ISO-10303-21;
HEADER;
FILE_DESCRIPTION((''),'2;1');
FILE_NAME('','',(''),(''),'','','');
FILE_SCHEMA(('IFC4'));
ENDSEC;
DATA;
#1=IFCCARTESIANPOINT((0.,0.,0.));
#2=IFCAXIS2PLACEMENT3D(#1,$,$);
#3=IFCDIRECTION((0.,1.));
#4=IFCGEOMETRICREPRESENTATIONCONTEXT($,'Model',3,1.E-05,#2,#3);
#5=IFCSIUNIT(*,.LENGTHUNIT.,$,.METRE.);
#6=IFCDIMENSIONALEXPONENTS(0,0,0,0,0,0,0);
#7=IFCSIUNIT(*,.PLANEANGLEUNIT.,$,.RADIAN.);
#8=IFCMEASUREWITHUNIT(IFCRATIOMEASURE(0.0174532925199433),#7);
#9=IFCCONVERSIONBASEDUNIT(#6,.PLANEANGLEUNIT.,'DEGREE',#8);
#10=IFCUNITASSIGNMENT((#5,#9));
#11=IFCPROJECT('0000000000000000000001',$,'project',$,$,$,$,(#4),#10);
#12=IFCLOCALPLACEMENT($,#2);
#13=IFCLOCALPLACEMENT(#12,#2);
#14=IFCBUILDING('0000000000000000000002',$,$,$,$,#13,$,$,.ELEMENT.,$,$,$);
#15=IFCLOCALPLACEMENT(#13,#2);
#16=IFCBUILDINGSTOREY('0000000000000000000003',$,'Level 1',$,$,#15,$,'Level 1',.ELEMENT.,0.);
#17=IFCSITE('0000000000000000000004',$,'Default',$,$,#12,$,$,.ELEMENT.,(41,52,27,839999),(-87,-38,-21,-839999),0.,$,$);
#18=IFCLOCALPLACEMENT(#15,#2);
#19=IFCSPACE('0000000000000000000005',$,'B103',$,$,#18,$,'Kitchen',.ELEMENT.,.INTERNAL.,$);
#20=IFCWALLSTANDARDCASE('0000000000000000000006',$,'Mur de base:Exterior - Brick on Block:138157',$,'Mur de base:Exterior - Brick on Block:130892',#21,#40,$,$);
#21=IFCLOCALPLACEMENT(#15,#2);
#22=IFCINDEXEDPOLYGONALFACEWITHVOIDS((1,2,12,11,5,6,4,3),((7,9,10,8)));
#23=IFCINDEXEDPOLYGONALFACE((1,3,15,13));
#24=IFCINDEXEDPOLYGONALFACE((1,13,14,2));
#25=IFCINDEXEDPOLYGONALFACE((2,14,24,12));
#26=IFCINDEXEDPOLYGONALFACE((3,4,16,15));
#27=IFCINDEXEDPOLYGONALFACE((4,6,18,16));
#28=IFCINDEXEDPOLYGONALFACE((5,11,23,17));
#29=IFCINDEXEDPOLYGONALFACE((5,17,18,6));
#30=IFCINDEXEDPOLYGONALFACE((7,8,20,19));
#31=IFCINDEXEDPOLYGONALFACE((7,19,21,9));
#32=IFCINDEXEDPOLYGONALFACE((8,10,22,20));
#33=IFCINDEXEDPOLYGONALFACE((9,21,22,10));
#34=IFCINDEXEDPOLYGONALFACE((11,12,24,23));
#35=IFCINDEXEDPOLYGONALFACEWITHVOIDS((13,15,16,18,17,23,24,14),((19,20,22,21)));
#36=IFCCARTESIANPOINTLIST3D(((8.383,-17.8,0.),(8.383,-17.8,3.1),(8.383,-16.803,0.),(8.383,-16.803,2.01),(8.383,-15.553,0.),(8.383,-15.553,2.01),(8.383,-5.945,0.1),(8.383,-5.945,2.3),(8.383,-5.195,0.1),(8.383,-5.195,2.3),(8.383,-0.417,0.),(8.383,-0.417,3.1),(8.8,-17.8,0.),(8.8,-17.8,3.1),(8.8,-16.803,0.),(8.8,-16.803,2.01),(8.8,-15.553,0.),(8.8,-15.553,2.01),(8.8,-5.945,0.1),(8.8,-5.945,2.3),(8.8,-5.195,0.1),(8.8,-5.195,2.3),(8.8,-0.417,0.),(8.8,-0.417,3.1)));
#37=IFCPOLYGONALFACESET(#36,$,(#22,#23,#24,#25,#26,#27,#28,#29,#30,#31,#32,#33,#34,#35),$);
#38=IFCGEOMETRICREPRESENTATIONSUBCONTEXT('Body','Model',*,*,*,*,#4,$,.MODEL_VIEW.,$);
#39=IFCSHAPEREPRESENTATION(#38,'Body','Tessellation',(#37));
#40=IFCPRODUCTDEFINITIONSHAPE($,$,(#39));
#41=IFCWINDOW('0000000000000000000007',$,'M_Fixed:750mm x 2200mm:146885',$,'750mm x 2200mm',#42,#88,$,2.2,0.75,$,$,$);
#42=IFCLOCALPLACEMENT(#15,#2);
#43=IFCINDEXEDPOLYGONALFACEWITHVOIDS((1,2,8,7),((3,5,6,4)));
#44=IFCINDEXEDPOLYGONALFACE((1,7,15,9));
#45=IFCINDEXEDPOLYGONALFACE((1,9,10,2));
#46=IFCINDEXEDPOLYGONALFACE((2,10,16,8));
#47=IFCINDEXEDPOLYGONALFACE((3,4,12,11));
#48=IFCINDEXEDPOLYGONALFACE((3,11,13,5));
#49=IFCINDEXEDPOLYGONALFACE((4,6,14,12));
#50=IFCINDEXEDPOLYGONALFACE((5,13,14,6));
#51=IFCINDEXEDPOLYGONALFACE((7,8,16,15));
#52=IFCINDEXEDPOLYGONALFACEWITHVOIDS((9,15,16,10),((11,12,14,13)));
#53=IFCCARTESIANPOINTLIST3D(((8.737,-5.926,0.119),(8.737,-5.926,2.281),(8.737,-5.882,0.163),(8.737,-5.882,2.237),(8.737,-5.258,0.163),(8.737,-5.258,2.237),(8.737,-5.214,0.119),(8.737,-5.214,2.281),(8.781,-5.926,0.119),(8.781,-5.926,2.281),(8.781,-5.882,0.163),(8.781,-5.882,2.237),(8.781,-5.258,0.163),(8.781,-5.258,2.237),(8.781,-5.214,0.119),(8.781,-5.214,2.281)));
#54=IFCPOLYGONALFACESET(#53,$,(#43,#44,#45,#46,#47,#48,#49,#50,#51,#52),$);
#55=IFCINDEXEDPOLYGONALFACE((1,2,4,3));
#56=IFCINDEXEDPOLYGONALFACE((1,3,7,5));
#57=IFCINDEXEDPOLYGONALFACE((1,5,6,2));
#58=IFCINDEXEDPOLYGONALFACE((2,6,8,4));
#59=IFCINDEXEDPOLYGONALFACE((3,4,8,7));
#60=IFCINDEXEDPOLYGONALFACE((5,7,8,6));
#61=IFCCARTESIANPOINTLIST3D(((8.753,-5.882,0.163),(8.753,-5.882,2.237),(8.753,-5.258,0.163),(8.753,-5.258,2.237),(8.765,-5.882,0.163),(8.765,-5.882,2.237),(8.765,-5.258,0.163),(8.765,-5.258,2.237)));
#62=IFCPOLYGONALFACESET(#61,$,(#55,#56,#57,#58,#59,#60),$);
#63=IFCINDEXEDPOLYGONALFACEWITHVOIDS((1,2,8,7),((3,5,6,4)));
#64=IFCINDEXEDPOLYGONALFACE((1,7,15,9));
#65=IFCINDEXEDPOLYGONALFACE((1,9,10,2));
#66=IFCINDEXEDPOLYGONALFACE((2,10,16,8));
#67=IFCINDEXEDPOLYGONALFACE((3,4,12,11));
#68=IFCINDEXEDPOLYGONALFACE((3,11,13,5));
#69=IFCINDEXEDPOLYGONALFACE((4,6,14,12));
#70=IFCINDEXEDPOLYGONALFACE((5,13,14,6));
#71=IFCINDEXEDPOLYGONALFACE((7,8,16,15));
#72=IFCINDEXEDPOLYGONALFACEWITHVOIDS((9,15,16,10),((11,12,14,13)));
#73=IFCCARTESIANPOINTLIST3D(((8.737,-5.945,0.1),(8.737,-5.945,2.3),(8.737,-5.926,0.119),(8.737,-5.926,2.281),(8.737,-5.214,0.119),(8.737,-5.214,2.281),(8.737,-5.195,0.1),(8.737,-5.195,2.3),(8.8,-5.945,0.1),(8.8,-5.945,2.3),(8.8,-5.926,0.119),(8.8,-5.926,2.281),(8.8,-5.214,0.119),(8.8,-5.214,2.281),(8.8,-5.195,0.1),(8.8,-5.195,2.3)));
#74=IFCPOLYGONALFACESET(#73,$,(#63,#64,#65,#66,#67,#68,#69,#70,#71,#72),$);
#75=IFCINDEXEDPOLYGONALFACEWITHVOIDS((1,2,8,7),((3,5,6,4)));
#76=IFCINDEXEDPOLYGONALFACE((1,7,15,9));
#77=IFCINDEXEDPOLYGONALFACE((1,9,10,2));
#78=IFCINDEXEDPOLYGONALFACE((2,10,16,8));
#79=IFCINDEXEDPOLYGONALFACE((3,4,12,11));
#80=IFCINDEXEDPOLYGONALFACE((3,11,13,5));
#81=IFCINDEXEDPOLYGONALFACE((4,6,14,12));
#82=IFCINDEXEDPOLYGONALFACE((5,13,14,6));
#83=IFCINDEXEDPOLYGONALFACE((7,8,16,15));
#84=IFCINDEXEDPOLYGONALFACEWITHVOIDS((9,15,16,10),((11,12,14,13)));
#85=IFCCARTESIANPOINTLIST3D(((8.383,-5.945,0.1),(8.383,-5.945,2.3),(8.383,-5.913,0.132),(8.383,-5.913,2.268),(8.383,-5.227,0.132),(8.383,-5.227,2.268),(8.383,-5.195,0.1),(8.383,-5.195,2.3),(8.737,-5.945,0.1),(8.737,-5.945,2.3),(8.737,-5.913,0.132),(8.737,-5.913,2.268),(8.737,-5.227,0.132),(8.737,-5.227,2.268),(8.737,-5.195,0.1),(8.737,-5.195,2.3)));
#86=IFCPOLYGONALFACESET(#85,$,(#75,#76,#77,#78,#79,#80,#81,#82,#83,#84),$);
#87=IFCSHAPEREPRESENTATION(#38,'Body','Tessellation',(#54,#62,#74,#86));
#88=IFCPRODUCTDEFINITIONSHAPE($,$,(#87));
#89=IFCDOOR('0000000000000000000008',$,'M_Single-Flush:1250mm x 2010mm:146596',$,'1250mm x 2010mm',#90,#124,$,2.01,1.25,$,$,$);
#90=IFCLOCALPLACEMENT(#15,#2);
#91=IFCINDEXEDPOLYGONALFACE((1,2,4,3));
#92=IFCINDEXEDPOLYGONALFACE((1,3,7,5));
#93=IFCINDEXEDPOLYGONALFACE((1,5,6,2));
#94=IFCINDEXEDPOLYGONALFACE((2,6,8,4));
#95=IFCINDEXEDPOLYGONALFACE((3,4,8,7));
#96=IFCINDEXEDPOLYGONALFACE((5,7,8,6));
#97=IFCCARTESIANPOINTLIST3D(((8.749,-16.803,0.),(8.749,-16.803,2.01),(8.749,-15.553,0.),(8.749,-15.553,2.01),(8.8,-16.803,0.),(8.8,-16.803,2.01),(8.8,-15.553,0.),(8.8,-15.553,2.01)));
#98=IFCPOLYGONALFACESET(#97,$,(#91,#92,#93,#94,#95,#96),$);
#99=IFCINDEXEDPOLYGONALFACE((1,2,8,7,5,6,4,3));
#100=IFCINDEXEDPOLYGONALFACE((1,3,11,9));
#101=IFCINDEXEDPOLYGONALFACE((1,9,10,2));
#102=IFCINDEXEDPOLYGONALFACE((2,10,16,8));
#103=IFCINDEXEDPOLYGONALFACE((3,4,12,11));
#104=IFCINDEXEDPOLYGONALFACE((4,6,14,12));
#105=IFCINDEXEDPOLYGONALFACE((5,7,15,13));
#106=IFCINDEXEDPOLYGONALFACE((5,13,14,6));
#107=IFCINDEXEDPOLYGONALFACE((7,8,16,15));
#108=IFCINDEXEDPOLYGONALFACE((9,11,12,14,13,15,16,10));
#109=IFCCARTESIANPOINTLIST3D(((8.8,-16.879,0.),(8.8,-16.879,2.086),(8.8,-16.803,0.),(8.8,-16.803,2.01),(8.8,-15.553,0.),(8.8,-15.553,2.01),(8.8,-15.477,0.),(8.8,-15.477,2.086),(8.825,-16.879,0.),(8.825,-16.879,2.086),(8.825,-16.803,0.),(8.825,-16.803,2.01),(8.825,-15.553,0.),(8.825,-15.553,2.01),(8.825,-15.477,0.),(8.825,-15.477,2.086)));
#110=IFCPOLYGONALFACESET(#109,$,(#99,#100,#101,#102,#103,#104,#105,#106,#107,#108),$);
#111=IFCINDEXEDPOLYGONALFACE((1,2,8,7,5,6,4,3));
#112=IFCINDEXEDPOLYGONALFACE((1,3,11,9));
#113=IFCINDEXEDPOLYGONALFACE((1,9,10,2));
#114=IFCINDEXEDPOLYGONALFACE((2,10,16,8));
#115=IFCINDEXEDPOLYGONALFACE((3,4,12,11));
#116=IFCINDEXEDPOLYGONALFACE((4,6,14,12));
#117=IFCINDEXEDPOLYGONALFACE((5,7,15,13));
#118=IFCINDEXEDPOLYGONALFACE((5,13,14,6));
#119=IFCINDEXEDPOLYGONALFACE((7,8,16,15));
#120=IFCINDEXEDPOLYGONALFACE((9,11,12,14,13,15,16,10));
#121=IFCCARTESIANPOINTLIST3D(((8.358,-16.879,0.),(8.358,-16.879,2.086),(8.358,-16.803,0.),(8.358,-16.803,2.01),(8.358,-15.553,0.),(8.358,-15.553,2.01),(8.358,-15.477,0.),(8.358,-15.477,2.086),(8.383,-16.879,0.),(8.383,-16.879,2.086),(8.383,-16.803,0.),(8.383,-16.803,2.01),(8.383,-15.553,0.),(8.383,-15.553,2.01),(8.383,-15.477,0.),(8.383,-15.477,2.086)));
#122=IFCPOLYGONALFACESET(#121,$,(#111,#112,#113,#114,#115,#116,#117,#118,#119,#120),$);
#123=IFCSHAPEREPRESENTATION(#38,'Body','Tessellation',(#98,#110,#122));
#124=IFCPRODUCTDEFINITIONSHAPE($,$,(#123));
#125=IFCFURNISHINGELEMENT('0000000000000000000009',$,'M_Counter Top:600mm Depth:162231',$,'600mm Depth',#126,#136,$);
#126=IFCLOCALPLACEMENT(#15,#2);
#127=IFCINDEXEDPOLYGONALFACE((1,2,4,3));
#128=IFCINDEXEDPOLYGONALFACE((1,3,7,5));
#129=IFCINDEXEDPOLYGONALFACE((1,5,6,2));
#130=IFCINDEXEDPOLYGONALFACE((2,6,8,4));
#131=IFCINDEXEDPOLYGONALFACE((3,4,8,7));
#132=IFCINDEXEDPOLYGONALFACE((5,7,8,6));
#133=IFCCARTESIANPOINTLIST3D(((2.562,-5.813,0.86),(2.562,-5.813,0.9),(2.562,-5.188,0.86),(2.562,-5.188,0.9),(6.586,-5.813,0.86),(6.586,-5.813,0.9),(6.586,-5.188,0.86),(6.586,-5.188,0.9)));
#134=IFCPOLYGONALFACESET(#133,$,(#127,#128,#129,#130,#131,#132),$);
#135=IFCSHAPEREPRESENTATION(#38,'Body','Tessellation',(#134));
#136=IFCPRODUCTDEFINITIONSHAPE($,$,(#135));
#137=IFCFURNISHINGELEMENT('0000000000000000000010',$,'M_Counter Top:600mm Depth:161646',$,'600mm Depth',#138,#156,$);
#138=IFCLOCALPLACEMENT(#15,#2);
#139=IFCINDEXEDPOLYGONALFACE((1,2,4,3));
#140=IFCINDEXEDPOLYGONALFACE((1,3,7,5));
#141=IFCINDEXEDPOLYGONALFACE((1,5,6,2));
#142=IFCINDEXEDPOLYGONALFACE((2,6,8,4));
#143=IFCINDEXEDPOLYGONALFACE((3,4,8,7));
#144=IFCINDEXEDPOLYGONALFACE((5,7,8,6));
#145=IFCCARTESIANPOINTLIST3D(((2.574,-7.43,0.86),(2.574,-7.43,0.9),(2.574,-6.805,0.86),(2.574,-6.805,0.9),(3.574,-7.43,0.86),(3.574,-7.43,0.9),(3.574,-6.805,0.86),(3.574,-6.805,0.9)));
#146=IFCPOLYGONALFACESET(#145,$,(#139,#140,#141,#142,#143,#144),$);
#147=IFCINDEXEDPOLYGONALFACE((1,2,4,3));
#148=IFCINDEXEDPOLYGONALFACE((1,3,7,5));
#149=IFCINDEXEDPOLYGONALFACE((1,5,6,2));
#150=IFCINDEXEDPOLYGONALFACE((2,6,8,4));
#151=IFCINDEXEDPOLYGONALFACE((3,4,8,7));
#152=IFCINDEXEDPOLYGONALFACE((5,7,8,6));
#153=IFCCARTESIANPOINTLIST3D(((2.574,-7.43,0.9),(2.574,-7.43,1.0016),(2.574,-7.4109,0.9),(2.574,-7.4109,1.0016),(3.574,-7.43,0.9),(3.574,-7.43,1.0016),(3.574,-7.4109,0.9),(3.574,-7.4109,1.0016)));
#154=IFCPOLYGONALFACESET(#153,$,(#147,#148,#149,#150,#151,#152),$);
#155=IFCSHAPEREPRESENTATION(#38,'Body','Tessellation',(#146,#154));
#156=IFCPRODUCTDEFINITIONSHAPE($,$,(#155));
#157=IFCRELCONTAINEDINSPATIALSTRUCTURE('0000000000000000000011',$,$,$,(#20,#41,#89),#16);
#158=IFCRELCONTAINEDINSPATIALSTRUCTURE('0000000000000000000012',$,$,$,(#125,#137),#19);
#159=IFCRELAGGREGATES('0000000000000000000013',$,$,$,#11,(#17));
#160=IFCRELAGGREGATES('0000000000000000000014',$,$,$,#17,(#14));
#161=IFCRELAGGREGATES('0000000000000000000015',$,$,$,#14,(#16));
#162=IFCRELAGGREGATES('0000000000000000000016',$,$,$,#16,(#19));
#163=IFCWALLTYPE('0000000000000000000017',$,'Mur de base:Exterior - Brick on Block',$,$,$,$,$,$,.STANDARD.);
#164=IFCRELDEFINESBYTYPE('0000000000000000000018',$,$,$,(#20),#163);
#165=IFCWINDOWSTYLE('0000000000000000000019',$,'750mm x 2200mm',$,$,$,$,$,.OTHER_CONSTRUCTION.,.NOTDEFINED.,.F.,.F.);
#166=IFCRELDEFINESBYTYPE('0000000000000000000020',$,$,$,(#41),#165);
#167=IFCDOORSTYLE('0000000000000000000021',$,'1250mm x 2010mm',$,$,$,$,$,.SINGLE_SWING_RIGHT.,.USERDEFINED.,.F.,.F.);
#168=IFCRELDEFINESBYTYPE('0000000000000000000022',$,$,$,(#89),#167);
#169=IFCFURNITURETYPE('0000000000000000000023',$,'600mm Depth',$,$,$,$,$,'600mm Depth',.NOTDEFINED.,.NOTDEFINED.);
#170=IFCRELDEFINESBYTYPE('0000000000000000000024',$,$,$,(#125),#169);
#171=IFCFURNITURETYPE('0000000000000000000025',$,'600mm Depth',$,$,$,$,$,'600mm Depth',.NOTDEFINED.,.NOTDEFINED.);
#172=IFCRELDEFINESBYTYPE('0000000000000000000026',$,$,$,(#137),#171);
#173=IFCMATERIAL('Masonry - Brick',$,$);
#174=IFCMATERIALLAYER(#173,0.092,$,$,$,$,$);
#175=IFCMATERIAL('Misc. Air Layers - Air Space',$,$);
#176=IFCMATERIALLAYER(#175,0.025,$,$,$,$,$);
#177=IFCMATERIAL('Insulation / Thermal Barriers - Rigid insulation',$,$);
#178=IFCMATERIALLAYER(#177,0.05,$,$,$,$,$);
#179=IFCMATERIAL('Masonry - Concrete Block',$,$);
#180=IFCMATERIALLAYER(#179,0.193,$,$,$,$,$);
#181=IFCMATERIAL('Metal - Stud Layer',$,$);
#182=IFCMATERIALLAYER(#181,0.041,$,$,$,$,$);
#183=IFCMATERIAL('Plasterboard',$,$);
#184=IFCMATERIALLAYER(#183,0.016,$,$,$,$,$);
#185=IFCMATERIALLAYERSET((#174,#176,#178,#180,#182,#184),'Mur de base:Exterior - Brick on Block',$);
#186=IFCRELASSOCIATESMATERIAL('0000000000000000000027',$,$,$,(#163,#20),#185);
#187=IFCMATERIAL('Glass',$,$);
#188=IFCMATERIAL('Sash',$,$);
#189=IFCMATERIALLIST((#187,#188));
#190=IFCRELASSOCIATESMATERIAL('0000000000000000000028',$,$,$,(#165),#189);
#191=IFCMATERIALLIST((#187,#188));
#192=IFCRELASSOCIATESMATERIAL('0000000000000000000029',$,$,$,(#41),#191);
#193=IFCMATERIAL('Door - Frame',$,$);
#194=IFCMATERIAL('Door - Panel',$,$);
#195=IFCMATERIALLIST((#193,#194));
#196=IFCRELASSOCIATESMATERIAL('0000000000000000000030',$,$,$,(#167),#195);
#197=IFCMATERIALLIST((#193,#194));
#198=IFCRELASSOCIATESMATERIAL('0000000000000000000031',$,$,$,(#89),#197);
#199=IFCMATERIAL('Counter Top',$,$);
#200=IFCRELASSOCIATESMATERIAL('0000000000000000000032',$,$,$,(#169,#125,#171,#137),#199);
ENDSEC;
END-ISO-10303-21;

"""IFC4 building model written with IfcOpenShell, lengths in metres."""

from ifc_helpers import new_model, entity, si_unit, converted_unit, direction, frame, frame_2d, origin, origin_2d_with_axis, place, context, subcontext, project, spatial, polyline, rectangle, outline, extrude, source, transform, mapped, material, material_list, layer, layer_set, layer_usage, type_object, type_shapes, element, fill, save


model = new_model("IFC4")

# Units and contexts
model_context = context("Model", 3, precision=1e-05, world=origin(), true_north=direction((0.0, 1.0)))
body_context = subcontext(model_context, "Body", "Model", "MODEL_VIEW")
ifc_project = project(units=[si_unit("LENGTHUNIT", "METRE"), converted_unit("PLANEANGLEUNIT", "DEGREE", entity("IfcRatioMeasure", 0.0174532925199433), si_unit("PLANEANGLEUNIT", "RADIAN"), dimensions=[0, 0, 0, 0, 0, 0, 0])], contexts=[model_context])

# Site, building, storey
site_placement = place(None, origin())
site = spatial("IfcSite", under=ifc_project, at=site_placement, Name="Default", CompositionType="ELEMENT", RefLatitude=(41, 52, 27, 839999), RefLongitude=(-87, -38, -21, -839999), RefElevation=0.0)
building_placement = place(site_placement, origin())
building = spatial("IfcBuilding", under=site, at=building_placement, CompositionType="ELEMENT")
storey_placement = place(building_placement, origin())
storey = spatial("IfcBuildingStorey", under=building, at=storey_placement, Name="Level 1", LongName="Level 1", CompositionType="ELEMENT", Elevation=0.0)

# Shared definitions
ifc_material_1 = material(Name="Metal - Stud Layer")
ifc_material_2 = material(Name="Plasterboard")
ifc_material_3 = material(Name="Masonry - Concrete Block")
ifc_material_4 = material(Name="Misc. Air Layers - Air Space")

# Shared definitions
ifc_material_5 = material(Name="Door - Frame")
ifc_material_6 = material(Name="Door - Panel")

# Wall, openings, window, door
ifc_material_7 = material(Name="Masonry - Brick")
ifc_layer_1 = layer(ifc_material_7, 0.092)
ifc_layer_2 = layer(ifc_material_4, 0.025)
ifc_material_8 = material(Name="Insulation / Thermal Barriers - Rigid insulation")
ifc_layer_3 = layer(ifc_material_8, 0.05)
ifc_layer_4 = layer(ifc_material_3, 0.193)
ifc_layer_5 = layer(ifc_material_1, 0.041)
ifc_layer_6 = layer(ifc_material_2, 0.016)
ifc_layer_set_1 = layer_set([ifc_layer_1, ifc_layer_2, ifc_layer_3, ifc_layer_4, ifc_layer_5, ifc_layer_6], Name="Mur de base:Exterior - Brick on Block")
ifc_layer_usage_1 = layer_usage(ifc_layer_set_1, "AXIS2", "NEGATIVE", 0.2085)
wall_type_1 = type_object("IfcWallType", Name="Mur de base:Exterior - Brick on Block", PredefinedType="STANDARD", material=ifc_layer_set_1)
wall_1_placement = place(storey_placement, frame((8.5915, -0.417, 0.0), z_axis=(0.0, 0.0, 1.0), x_axis=(0.0, -1.0, 0.0)))
wall_1 = element("IfcWallStandardCase", 1, at=wall_1_placement, inside=storey, type_object=wall_type_1, material=ifc_layer_usage_1, Name="Mur de base:Exterior - Brick on Block:138157", ObjectType="Mur de base:Exterior - Brick on Block:130892", context=body_context, shape_type="SweptSolid", body=[
    extrude(rectangle(XDim=17.383, YDim=0.417, at=frame_2d((8.6915, 0.0), x_axis=(-1.0, 0.0))), origin(), (0.0, 0.0, 1.0), 3.1),
])
opening_1_placement = place(wall_1_placement, frame((4.778, -0.2085, 0.1)))
opening_1 = element("IfcOpeningElement", 2, at=opening_1_placement, cuts=wall_1, ObjectType="Opening", context=body_context, shape_type="SweptSolid", body=[
    extrude(rectangle(XDim=2.2, YDim=0.75, at=frame_2d((1.1, 0.375), x_axis=(1.0, 0.0))), frame((0.0, 0.0, 0.0), z_axis=(0.0, 1.0, 0.0), x_axis=(0.0, 0.0, 1.0)), (0.0, 0.0, 1.0), 0.417),
])
opening_2_placement = place(wall_1_placement, frame((15.136, -0.2085, 0.0)))
opening_2 = element("IfcOpeningElement", 3, at=opening_2_placement, cuts=wall_1, ObjectType="Opening", context=body_context, shape_type="SweptSolid", body=[
    extrude(rectangle(XDim=1.25, YDim=2.01, at=frame_2d((1.005, 0.625), x_axis=(0.0, 1.0))), frame((0.0, 0.0, 0.0), z_axis=(0.0, 1.0, 0.0), x_axis=(0.0, 0.0, 1.0)), (0.0, 0.0, 1.0), 0.417),
])
ifc_material_9 = material(Name="Glass")
ifc_material_10 = material(Name="Sash")
ifc_material_list_1 = material_list([ifc_material_9, ifc_material_10])
ifc_material_list_2 = material_list([ifc_material_9, ifc_material_10])
window_style = type_object("IfcWindowStyle", Name="750mm x 2200mm", ConstructionType="OTHER_CONSTRUCTION", OperationType="NOTDEFINED", ParameterTakesPrecedence=False, Sizeable=False, material=ifc_material_list_2)
shared_shape_1 = source(origin(), body_context, "Body", "SweptSolid", [
    extrude(outline(polyline([(-0.356, -1.081), (0.356, -1.081), (0.356, 1.081), (-0.356, 1.081), (-0.356, -1.081)]), holes=[polyline([(-0.312, -1.037), (-0.312, 1.037), (0.312, 1.037), (0.312, -1.037), (-0.312, -1.037)])]), frame((0.375, 0.354, 1.1), z_axis=(0.0, 1.0, 0.0), x_axis=(1.0, 0.0, 0.0)), (0.0, 0.0, 1.0), 0.044),
    extrude(rectangle(XDim=0.012, YDim=0.624, at=origin_2d_with_axis()), frame((0.375, 0.376, 0.063), z_axis=(0.0, 0.0, 1.0), x_axis=(0.0, -1.0, 0.0)), (0.0, 0.0, 1.0), 2.074),
    extrude(outline(polyline([(-0.375, -1.1), (0.375, -1.1), (0.375, 1.1), (-0.375, 1.1), (-0.375, -1.1)]), holes=[polyline([(-0.356, -1.081), (-0.356, 1.081), (0.356, 1.081), (0.356, -1.081), (-0.356, -1.081)])]), frame((0.375, 0.354, 1.1), z_axis=(0.0, 1.0, 0.0), x_axis=(1.0, 0.0, 0.0)), (0.0, 0.0, 1.0), 0.063),
    extrude(outline(polyline([(-0.375, -1.1), (0.375, -1.1), (0.375, 1.1), (-0.375, 1.1), (-0.375, -1.1)]), holes=[polyline([(-0.343, -1.068), (-0.343, 1.068), (0.343, 1.068), (0.343, -1.068), (-0.343, -1.068)])]), frame((0.375, 0.0, 1.1), z_axis=(0.0, 1.0, 0.0), x_axis=(1.0, 0.0, 0.0)), (0.0, 0.0, 1.0), 0.354),
])
type_shapes(window_style, [shared_shape_1])
window_placement = place(opening_1_placement, origin())
window = element("IfcWindow", 4, at=window_placement, inside=storey, type_object=window_style, material=ifc_material_list_1, Name="M_Fixed:750mm x 2200mm:146885", ObjectType="750mm x 2200mm", OverallHeight=2.2, OverallWidth=0.75, context=body_context, shape_type="MappedRepresentation", body=[
    mapped(shared_shape_1, transform((0.0, 0.0, 0.0), scale=1.0)),
])
fill(opening_1, window)
ifc_material_list_3 = material_list([ifc_material_5, ifc_material_6])
ifc_material_list_4 = material_list([ifc_material_5, ifc_material_6])
door_style_1 = type_object("IfcDoorStyle", Name="1250mm x 2010mm", ConstructionType="USERDEFINED", OperationType="SINGLE_SWING_RIGHT", ParameterTakesPrecedence=False, Sizeable=False, material=ifc_material_list_4)
shared_shape_2 = source(origin(), body_context, "Body", "SweptSolid", [
    extrude(rectangle(XDim=0.051, YDim=1.25, at=frame_2d((0.0, 0.0), x_axis=(1.0, 0.0))), frame((0.625, 0.3915, 0.0), z_axis=(0.0, 0.0, 1.0), x_axis=(0.0, 1.0, 0.0)), (0.0, 0.0, 1.0), 2.01),
    extrude(outline(polyline([(-0.701, -1.062), (0.701, -1.062), (0.701, 1.024), (0.625, 1.024), (0.625, -0.986), (-0.625, -0.986), (-0.625, 1.024), (-0.701, 1.024), (-0.701, -1.062)])), frame((0.625, 0.417, 1.024), z_axis=(0.0, 1.0, 0.0), x_axis=(1.0, 0.0, 0.0)), (0.0, 0.0, 1.0), 0.025),
    extrude(outline(polyline([(-1.062, -0.701), (1.024, -0.701), (1.024, -0.625), (-0.986, -0.625), (-0.986, 0.625), (1.024, 0.625), (1.024, 0.701), (-1.062, 0.701), (-1.062, -0.701)])), frame((0.625, -0.025, 1.024), z_axis=(0.0, 1.0, 0.0), x_axis=(0.0, 0.0, -1.0)), (0.0, 0.0, 1.0), 0.025),
])
type_shapes(door_style_1, [shared_shape_2])
door_1_placement = place(opening_2_placement, origin())
door_1 = element("IfcDoor", 5, at=door_1_placement, inside=storey, type_object=door_style_1, material=ifc_material_list_3, Name="M_Single-Flush:1250mm x 2010mm:146596", ObjectType="1250mm x 2010mm", OverallHeight=2.01, OverallWidth=1.25, context=body_context, shape_type="MappedRepresentation", body=[
    mapped(shared_shape_2, transform((0.0, 0.0, 0.0), scale=1.0)),
])
fill(opening_2, door_1)

# Shared definitions
space_placement = place(storey_placement, origin())
space = spatial("IfcSpace", under=storey, at=space_placement, Name="B103", LongName="Kitchen", CompositionType="ELEMENT", PredefinedType="INTERNAL")

# Furnishing elements
ifc_material_11 = material(Name="Counter Top")
furniture_type_1 = type_object("IfcFurnitureType", Name="600mm Depth", ElementType="600mm Depth", AssemblyPlace="NOTDEFINED", material=ifc_material_11)
shared_shape_3 = source(origin(), body_context, "Body", "SweptSolid", [
    extrude(rectangle(XDim=4.024, YDim=0.625, at=frame_2d((0.0, 0.0), x_axis=(1.0, 0.0))), frame((0.8115, -0.3125, 0.86), z_axis=(0.0, 0.0, 1.0), x_axis=(-1.0, 0.0, 0.0)), (0.0, 0.0, 1.0), 0.04),
])
type_shapes(furniture_type_1, [shared_shape_3])
furnishing_1_placement = place(space_placement, frame((3.7625, -5.188, 0.0)))
element("IfcFurnishingElement", 6, at=furnishing_1_placement, inside=space, type_object=furniture_type_1, material=ifc_material_11, Name="M_Counter Top:600mm Depth:162231", ObjectType="600mm Depth", context=body_context, shape_type="MappedRepresentation", body=[
    mapped(shared_shape_3, transform((0.0, 0.0, 0.0), scale=1.0)),
])
furniture_type_2 = type_object("IfcFurnitureType", Name="600mm Depth", ElementType="600mm Depth", AssemblyPlace="NOTDEFINED", material=ifc_material_11)
shared_shape_4 = source(origin(), body_context, "Body", "SweptSolid", [
    extrude(rectangle(XDim=1.0, YDim=0.625, at=frame_2d((0.0, 0.0), x_axis=(1.0, 0.0))), frame((-0.7005, -0.3125, 0.86), z_axis=(0.0, 0.0, 1.0), x_axis=(-1.0, 0.0, 0.0)), (0.0, 0.0, 1.0), 0.04),
    extrude(rectangle(XDim=0.0191, YDim=1.0, at=frame_2d((0.0, 0.0), x_axis=(1.0, 0.0))), frame((-0.7005, -0.0095, 0.9), z_axis=(0.0, 0.0, 1.0), x_axis=(0.0, -1.0, 0.0)), (0.0, 0.0, 1.0), 0.1016),
])
type_shapes(furniture_type_2, [shared_shape_4])
furnishing_2_placement = place(space_placement, frame((2.3735, -7.43, 0.0), z_axis=(0.0, 0.0, 1.0), x_axis=(-1.0, 0.0, 0.0)))
element("IfcFurnishingElement", 7, at=furnishing_2_placement, inside=space, type_object=furniture_type_2, material=ifc_material_11, Name="M_Counter Top:600mm Depth:161646", ObjectType="600mm Depth", context=body_context, shape_type="MappedRepresentation", body=[
    mapped(shared_shape_4, transform((0.0, 0.0, 0.0), scale=1.0)),
])

save(model, "model.ifc")
